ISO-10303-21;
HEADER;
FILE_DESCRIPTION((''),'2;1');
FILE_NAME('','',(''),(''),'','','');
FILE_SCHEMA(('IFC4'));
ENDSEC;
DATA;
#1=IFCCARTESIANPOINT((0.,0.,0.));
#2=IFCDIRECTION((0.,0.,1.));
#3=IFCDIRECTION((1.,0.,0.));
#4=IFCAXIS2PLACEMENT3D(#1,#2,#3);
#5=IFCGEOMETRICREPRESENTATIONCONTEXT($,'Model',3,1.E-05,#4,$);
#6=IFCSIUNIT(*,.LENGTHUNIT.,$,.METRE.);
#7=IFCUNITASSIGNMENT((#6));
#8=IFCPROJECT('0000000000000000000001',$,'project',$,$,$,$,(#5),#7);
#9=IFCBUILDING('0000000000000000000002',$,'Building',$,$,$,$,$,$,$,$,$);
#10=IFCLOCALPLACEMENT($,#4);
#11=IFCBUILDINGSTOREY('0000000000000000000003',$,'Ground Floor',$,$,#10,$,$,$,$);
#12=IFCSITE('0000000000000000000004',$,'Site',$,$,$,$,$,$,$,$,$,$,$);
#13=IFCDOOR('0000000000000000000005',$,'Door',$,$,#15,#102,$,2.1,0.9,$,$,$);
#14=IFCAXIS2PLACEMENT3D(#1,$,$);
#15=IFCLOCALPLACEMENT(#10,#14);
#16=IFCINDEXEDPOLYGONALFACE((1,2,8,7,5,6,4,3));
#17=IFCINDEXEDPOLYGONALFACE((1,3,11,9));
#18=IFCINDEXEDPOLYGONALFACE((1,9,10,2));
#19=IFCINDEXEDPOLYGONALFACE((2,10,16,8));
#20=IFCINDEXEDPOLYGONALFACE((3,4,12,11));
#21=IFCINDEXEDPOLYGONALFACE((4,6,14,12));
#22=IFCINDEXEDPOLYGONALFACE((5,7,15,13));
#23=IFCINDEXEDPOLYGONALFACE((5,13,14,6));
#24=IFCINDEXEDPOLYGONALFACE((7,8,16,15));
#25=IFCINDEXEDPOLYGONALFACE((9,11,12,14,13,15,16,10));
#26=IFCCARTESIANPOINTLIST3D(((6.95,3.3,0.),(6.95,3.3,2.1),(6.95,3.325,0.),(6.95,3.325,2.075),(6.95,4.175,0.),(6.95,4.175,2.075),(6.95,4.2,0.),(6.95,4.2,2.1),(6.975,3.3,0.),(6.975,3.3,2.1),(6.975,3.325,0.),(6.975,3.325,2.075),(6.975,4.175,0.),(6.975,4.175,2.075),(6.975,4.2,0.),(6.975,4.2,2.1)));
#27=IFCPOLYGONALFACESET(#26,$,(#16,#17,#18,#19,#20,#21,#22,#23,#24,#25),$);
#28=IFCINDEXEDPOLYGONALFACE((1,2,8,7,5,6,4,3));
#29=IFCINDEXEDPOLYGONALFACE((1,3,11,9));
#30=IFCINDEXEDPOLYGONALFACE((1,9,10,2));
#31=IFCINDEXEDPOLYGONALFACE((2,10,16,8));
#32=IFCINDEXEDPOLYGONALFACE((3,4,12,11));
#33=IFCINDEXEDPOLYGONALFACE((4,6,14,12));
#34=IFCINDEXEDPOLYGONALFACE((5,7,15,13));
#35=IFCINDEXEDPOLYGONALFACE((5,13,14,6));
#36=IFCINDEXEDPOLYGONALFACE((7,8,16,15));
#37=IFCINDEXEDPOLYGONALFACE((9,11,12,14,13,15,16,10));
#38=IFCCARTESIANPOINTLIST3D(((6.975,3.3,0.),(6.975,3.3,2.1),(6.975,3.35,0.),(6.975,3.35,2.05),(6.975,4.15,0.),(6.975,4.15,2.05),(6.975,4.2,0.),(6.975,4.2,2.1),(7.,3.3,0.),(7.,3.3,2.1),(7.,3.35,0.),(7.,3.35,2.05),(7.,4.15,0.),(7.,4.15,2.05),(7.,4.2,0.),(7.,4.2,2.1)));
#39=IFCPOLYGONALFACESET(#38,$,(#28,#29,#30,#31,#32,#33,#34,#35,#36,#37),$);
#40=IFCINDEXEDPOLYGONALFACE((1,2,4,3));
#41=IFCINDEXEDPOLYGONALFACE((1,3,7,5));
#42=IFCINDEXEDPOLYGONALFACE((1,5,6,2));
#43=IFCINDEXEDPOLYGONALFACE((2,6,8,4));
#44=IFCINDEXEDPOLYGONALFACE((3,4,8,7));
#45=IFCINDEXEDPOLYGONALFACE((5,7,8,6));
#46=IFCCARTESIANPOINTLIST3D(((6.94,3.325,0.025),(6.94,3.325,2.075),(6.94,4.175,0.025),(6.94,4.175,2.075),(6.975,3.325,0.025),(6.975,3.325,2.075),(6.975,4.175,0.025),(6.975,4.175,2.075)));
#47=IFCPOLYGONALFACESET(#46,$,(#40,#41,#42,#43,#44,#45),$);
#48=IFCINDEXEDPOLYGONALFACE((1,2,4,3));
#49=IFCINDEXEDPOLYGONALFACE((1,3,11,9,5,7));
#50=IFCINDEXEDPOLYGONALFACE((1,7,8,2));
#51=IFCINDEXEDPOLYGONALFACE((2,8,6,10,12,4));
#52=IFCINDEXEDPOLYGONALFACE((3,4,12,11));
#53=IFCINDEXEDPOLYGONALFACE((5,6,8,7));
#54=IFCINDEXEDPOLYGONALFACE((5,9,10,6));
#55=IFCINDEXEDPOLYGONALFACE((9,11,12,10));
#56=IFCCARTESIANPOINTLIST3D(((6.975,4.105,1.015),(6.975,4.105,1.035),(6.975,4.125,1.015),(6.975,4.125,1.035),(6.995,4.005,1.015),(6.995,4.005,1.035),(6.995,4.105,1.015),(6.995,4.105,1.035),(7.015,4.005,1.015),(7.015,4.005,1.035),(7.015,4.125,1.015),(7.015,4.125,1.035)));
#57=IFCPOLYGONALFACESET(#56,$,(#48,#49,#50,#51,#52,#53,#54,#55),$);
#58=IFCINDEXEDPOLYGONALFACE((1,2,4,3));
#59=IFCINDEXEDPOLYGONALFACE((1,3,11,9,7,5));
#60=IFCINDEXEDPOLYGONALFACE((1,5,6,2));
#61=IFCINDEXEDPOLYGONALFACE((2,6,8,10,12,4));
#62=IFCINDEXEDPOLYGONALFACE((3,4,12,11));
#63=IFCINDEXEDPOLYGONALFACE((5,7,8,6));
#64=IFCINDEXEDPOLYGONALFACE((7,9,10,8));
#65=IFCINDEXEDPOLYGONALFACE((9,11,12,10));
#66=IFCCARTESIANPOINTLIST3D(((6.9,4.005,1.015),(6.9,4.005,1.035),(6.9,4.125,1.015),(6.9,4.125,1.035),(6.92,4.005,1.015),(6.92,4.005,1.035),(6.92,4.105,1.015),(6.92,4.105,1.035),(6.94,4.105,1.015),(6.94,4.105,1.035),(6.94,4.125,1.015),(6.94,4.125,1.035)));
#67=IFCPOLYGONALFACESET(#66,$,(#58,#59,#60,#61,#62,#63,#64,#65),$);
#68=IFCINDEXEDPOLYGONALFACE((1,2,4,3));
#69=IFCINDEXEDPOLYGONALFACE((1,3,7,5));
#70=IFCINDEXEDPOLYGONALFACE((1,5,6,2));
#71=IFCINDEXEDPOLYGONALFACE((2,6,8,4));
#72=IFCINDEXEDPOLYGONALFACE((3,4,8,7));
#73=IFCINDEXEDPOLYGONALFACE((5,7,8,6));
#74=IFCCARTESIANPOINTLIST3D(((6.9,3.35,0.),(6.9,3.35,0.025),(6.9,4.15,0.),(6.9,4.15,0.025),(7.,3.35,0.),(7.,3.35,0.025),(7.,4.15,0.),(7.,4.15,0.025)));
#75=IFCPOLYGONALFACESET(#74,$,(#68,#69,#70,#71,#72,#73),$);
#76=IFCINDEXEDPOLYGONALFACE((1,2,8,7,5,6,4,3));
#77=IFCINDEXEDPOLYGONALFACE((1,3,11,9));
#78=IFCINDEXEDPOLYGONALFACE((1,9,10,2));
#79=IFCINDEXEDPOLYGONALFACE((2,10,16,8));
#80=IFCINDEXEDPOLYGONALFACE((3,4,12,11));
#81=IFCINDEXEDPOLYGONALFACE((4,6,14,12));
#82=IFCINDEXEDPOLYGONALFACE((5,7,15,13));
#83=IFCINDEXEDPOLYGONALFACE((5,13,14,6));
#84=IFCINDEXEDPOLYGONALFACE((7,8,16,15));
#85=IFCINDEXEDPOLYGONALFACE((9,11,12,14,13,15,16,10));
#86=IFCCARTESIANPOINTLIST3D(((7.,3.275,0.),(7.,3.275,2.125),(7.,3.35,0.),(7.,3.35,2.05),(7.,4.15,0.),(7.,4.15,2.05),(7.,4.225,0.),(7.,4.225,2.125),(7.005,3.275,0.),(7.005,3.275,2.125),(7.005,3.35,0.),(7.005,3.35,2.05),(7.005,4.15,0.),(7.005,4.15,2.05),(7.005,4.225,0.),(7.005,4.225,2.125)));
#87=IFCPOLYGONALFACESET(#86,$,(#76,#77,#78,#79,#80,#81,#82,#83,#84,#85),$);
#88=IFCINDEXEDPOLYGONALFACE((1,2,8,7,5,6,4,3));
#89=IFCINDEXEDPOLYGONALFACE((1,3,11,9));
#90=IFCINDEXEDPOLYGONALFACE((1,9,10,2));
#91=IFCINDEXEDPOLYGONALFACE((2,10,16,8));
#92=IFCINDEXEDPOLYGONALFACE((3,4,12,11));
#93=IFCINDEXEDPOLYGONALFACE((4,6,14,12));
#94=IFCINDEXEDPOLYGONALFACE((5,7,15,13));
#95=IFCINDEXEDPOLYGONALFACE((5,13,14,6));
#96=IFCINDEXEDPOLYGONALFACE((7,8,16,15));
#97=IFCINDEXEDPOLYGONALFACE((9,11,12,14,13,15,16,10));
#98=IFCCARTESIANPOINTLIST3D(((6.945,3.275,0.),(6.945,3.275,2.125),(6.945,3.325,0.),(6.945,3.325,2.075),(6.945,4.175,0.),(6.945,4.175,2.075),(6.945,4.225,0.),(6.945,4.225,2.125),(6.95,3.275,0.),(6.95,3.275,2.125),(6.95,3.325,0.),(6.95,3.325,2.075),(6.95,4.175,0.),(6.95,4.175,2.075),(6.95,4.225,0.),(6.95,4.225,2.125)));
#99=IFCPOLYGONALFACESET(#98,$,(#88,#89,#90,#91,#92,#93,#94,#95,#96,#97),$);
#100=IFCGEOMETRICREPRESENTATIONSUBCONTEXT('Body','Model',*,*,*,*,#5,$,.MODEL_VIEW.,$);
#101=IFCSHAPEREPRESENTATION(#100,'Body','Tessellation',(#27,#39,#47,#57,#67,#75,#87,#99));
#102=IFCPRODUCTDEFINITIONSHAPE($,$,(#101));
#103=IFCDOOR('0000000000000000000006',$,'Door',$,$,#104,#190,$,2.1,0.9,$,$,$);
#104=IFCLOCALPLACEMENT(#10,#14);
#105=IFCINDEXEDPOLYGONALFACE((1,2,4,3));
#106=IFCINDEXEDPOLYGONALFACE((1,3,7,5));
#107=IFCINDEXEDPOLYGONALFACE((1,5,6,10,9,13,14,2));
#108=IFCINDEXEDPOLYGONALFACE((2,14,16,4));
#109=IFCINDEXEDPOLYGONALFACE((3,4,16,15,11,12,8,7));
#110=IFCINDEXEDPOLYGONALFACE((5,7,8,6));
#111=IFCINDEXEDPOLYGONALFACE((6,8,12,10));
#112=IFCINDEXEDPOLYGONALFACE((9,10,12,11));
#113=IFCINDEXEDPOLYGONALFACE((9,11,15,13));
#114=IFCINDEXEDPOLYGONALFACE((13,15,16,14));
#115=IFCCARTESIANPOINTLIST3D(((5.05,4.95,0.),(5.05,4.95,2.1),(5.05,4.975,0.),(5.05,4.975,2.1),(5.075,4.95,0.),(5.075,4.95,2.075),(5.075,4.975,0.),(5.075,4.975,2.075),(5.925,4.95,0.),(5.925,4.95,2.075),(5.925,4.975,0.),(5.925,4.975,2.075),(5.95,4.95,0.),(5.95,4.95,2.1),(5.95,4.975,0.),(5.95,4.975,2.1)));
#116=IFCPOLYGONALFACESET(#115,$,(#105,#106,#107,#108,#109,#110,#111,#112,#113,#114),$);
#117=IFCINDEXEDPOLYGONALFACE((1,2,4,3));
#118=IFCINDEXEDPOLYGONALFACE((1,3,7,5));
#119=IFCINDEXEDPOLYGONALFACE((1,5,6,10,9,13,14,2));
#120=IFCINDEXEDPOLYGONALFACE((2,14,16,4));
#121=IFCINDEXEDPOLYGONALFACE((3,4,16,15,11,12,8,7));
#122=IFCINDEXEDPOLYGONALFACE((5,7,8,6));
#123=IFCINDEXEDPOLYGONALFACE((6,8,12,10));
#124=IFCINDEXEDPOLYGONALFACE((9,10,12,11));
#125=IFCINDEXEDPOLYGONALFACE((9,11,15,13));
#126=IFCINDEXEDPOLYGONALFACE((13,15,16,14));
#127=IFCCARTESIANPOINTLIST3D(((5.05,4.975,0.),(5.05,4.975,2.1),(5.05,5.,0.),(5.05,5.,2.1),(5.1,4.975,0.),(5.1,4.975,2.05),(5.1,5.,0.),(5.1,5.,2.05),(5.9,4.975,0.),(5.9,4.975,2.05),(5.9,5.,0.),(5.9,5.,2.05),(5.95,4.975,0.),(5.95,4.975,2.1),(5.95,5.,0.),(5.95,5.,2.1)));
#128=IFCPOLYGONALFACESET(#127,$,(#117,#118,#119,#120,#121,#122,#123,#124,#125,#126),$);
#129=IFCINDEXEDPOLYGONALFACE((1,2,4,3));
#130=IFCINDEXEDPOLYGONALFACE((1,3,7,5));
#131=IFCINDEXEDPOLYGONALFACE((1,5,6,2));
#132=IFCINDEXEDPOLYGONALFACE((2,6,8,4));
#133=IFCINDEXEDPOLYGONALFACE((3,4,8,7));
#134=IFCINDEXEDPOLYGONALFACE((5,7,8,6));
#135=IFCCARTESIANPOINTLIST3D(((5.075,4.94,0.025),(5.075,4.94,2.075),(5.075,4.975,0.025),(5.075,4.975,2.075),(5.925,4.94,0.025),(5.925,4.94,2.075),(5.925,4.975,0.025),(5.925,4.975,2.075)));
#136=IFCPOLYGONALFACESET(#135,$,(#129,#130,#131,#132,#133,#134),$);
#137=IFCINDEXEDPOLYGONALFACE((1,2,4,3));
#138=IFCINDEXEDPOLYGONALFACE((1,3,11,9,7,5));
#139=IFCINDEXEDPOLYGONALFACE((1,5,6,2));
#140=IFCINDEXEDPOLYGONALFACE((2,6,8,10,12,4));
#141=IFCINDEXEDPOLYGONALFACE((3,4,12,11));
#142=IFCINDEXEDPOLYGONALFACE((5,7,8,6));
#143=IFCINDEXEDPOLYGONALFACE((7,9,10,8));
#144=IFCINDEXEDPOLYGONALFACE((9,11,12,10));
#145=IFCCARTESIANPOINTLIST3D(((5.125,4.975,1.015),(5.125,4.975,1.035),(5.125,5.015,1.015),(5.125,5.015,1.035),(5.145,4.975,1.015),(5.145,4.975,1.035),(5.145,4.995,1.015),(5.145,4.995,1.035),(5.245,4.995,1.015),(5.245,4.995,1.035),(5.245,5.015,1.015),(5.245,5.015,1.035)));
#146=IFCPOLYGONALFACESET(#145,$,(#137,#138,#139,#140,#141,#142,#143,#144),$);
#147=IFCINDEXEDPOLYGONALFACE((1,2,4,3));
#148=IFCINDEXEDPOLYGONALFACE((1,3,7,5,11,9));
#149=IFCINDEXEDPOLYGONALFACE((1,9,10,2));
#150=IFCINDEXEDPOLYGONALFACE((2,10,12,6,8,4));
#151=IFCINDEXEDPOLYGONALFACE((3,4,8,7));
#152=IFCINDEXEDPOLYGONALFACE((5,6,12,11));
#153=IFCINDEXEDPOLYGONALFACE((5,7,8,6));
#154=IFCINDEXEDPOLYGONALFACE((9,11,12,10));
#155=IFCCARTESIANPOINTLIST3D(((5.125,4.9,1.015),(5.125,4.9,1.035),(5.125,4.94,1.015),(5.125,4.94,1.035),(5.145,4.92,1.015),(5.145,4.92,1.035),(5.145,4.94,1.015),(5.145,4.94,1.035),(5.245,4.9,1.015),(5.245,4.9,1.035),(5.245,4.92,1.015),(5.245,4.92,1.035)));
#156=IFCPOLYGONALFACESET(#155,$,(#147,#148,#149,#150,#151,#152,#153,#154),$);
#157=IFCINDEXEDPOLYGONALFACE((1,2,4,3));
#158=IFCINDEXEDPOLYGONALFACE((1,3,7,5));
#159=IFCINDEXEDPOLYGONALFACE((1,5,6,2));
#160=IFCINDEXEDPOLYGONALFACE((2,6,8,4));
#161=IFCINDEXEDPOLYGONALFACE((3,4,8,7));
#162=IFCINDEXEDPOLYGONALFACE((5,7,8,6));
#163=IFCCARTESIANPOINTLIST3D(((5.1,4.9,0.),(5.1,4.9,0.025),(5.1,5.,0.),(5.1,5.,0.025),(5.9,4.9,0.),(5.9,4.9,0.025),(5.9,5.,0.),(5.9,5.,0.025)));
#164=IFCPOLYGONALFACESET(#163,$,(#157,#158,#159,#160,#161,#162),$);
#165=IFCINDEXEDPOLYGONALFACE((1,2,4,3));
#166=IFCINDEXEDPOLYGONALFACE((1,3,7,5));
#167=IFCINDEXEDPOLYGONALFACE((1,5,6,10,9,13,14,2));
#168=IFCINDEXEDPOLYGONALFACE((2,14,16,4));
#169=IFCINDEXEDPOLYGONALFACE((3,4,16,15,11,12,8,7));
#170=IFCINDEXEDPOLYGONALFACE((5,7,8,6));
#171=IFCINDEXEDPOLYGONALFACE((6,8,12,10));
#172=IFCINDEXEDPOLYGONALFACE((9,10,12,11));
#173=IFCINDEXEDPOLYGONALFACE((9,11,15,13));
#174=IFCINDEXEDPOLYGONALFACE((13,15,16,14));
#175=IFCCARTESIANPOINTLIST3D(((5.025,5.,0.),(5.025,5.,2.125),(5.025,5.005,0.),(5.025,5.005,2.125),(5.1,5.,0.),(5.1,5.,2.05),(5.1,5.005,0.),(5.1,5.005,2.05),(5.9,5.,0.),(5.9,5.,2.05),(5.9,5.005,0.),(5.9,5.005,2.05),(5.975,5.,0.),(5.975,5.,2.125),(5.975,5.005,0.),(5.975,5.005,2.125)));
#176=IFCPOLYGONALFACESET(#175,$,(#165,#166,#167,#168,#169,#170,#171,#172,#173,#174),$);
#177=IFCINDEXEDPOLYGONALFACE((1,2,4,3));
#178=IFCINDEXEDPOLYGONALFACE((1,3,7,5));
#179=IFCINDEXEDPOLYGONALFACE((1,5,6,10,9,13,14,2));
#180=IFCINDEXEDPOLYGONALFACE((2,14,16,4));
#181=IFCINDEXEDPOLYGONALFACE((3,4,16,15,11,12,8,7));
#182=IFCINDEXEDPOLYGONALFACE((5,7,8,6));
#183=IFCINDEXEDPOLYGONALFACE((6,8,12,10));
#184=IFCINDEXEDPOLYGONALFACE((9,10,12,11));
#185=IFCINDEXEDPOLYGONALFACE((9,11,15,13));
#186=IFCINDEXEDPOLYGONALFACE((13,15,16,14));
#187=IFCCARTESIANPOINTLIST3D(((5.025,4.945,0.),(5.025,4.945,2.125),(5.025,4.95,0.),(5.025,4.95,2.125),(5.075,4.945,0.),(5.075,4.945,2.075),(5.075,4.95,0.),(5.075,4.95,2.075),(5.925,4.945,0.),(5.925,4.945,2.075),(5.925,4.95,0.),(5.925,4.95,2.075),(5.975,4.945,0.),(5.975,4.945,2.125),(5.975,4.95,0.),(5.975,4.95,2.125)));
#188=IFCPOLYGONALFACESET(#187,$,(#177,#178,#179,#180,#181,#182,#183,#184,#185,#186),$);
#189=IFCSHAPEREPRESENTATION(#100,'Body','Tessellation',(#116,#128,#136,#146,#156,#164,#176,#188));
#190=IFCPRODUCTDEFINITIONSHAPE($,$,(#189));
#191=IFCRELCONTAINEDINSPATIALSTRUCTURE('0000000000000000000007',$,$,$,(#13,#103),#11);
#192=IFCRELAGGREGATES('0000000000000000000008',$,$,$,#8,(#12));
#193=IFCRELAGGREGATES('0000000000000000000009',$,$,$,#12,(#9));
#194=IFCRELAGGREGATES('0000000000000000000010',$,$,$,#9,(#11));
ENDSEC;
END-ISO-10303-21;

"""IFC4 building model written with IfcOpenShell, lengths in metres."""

from ifc_helpers import new_model, si_unit, frame, origin_with_axes, place, context, subcontext, project, spatial, line, indexed_curve, outline, extrude, element, save


model = new_model("IFC4")

# Units and contexts
model_context = context("Model", 3, precision=1e-05, world=origin_with_axes())
body_context = subcontext(model_context, "Body", "Model", "MODEL_VIEW")
ifc_project = project(units=[si_unit("LENGTHUNIT", "METRE")], contexts=[model_context])

# Site, building, storey
site = spatial("IfcSite", under=ifc_project, Name="Site")
building = spatial("IfcBuilding", under=site, Name="Building")
storey_placement = place(None, origin_with_axes())
storey = spatial("IfcBuildingStorey", under=building, at=storey_placement, Name="Ground Floor")

# Doors
door_1_placement = place(storey_placement, frame((7.0, 3.3, 0.0), z_axis=(0.0, 0.0, 1.0), x_axis=(0.0, 1.0, 0.0)))
element("IfcDoor", 1, at=door_1_placement, inside=storey, Name="Door", OverallHeight=2.1, OverallWidth=0.9, context=body_context, shape_type="SweptSolid", body=[
    extrude(outline(indexed_curve([(0.0, 0.0), (0.0, 2.1), (0.9, 2.1), (0.9, 0.0), (0.875, 0.0), (0.875, 2.075), (0.025, 2.075), (0.025, 0.0)], segments=[line(1, 2, 3, 4, 5, 6, 7, 8, 1)])), frame((0.0, 0.025, 0.0), z_axis=(0.0, -1.0, 0.0), x_axis=(1.0, 0.0, 0.0)), (0.0, 0.0, -1.0), 0.025),
    extrude(outline(indexed_curve([(0.0, 0.0), (0.0, 2.1), (0.9, 2.1), (0.9, 0.0), (0.85, 0.0), (0.85, 2.05), (0.05, 2.05), (0.05, 0.0)], segments=[line(1, 2, 3, 4, 5, 6, 7, 8, 1)])), frame((0.0, 0.0, 0.0), z_axis=(0.0, -1.0, 0.0), x_axis=(1.0, 0.0, 0.0)), (0.0, 0.0, -1.0), 0.025),
    extrude(outline(indexed_curve([(0.0, 0.0), (0.85, 0.0), (0.85, 0.035), (0.0, 0.035)], segments=[line(1, 2, 3, 4, 1)])), frame((0.025, 0.025, 0.025), z_axis=(0.0, 0.0, 1.0), x_axis=(1.0, 0.0, 0.0)), (0.0, 0.0, 1.0), 2.05),
    extrude(outline(indexed_curve([(0.0, 0.0), (0.0, -0.04), (-0.12, -0.04), (-0.12, -0.02), (-0.02, -0.02), (-0.02, 0.0)], segments=[line(1, 2, 3, 4, 5, 6, 1)])), frame((0.825, 0.025, 1.015), z_axis=(0.0, 0.0, 1.0), x_axis=(1.0, 0.0, 0.0)), (0.0, 0.0, 1.0), 0.02),
    extrude(outline(indexed_curve([(0.0, 0.0), (0.0, 0.04), (-0.12, 0.04), (-0.12, 0.02), (-0.02, 0.02), (-0.02, 0.0)], segments=[line(1, 2, 3, 4, 5, 6, 1)])), frame((0.825, 0.06, 1.015), z_axis=(0.0, 0.0, 1.0), x_axis=(1.0, 0.0, 0.0)), (0.0, 0.0, 1.0), 0.02),
    extrude(outline(indexed_curve([(0.0, 0.0), (0.8, 0.0), (0.8, 0.1), (0.0, 0.1)], segments=[line(1, 2, 3, 4, 1)])), frame((0.05, 0.0, 0.0), z_axis=(0.0, 0.0, 1.0), x_axis=(1.0, 0.0, 0.0)), (0.0, 0.0, 1.0), 0.025),
    extrude(outline(indexed_curve([(0.0, 0.0), (0.0, 2.125), (0.95, 2.125), (0.95, 0.0), (0.875, 0.0), (0.875, 2.05), (0.075, 2.05), (0.075, 0.0)], segments=[line(1, 2, 3, 4, 5, 6, 7, 8, 1)])), frame((-0.025, -0.005, 0.0), z_axis=(0.0, -1.0, 0.0), x_axis=(1.0, 0.0, 0.0)), (0.0, 0.0, -1.0), 0.005),
    extrude(outline(indexed_curve([(0.0, 0.0), (0.0, 2.125), (0.95, 2.125), (0.95, 0.0), (0.9, 0.0), (0.9, 2.075), (0.05, 2.075), (0.05, 0.0)], segments=[line(1, 2, 3, 4, 5, 6, 7, 8, 1)])), frame((-0.025, 0.05, 0.0), z_axis=(0.0, -1.0, 0.0), x_axis=(1.0, 0.0, 0.0)), (0.0, 0.0, -1.0), 0.005),
])
door_2_placement = place(storey_placement, frame((5.95, 5.0, 0.0), z_axis=(0.0, 0.0, 1.0), x_axis=(-1.0, 0.0, 0.0)))
element("IfcDoor", 2, at=door_2_placement, inside=storey, Name="Door", OverallHeight=2.1, OverallWidth=0.9, context=body_context, shape_type="SweptSolid", body=[
    extrude(outline(indexed_curve([(0.0, 0.0), (0.0, 2.1), (0.9, 2.1), (0.9, 0.0), (0.875, 0.0), (0.875, 2.075), (0.025, 2.075), (0.025, 0.0)], segments=[line(1, 2, 3, 4, 5, 6, 7, 8, 1)])), frame((0.0, 0.025, 0.0), z_axis=(0.0, -1.0, 0.0), x_axis=(1.0, 0.0, 0.0)), (0.0, 0.0, -1.0), 0.025),
    extrude(outline(indexed_curve([(0.0, 0.0), (0.0, 2.1), (0.9, 2.1), (0.9, 0.0), (0.85, 0.0), (0.85, 2.05), (0.05, 2.05), (0.05, 0.0)], segments=[line(1, 2, 3, 4, 5, 6, 7, 8, 1)])), frame((0.0, 0.0, 0.0), z_axis=(0.0, -1.0, 0.0), x_axis=(1.0, 0.0, 0.0)), (0.0, 0.0, -1.0), 0.025),
    extrude(outline(indexed_curve([(0.0, 0.0), (0.85, 0.0), (0.85, 0.035), (0.0, 0.035)], segments=[line(1, 2, 3, 4, 1)])), frame((0.025, 0.025, 0.025), z_axis=(0.0, 0.0, 1.0), x_axis=(1.0, 0.0, 0.0)), (0.0, 0.0, 1.0), 2.05),
    extrude(outline(indexed_curve([(0.0, 0.0), (0.0, -0.04), (-0.12, -0.04), (-0.12, -0.02), (-0.02, -0.02), (-0.02, 0.0)], segments=[line(1, 2, 3, 4, 5, 6, 1)])), frame((0.825, 0.025, 1.015), z_axis=(0.0, 0.0, 1.0), x_axis=(1.0, 0.0, 0.0)), (0.0, 0.0, 1.0), 0.02),
    extrude(outline(indexed_curve([(0.0, 0.0), (0.0, 0.04), (-0.12, 0.04), (-0.12, 0.02), (-0.02, 0.02), (-0.02, 0.0)], segments=[line(1, 2, 3, 4, 5, 6, 1)])), frame((0.825, 0.06, 1.015), z_axis=(0.0, 0.0, 1.0), x_axis=(1.0, 0.0, 0.0)), (0.0, 0.0, 1.0), 0.02),
    extrude(outline(indexed_curve([(0.0, 0.0), (0.8, 0.0), (0.8, 0.1), (0.0, 0.1)], segments=[line(1, 2, 3, 4, 1)])), frame((0.05, 0.0, 0.0), z_axis=(0.0, 0.0, 1.0), x_axis=(1.0, 0.0, 0.0)), (0.0, 0.0, 1.0), 0.025),
    extrude(outline(indexed_curve([(0.0, 0.0), (0.0, 2.125), (0.95, 2.125), (0.95, 0.0), (0.875, 0.0), (0.875, 2.05), (0.075, 2.05), (0.075, 0.0)], segments=[line(1, 2, 3, 4, 5, 6, 7, 8, 1)])), frame((-0.025, -0.005, 0.0), z_axis=(0.0, -1.0, 0.0), x_axis=(1.0, 0.0, 0.0)), (0.0, 0.0, -1.0), 0.005),
    extrude(outline(indexed_curve([(0.0, 0.0), (0.0, 2.125), (0.95, 2.125), (0.95, 0.0), (0.9, 0.0), (0.9, 2.075), (0.05, 2.075), (0.05, 0.0)], segments=[line(1, 2, 3, 4, 5, 6, 7, 8, 1)])), frame((-0.025, 0.05, 0.0), z_axis=(0.0, -1.0, 0.0), x_axis=(1.0, 0.0, 0.0)), (0.0, 0.0, -1.0), 0.005),
])

save(model, "model.ifc")
